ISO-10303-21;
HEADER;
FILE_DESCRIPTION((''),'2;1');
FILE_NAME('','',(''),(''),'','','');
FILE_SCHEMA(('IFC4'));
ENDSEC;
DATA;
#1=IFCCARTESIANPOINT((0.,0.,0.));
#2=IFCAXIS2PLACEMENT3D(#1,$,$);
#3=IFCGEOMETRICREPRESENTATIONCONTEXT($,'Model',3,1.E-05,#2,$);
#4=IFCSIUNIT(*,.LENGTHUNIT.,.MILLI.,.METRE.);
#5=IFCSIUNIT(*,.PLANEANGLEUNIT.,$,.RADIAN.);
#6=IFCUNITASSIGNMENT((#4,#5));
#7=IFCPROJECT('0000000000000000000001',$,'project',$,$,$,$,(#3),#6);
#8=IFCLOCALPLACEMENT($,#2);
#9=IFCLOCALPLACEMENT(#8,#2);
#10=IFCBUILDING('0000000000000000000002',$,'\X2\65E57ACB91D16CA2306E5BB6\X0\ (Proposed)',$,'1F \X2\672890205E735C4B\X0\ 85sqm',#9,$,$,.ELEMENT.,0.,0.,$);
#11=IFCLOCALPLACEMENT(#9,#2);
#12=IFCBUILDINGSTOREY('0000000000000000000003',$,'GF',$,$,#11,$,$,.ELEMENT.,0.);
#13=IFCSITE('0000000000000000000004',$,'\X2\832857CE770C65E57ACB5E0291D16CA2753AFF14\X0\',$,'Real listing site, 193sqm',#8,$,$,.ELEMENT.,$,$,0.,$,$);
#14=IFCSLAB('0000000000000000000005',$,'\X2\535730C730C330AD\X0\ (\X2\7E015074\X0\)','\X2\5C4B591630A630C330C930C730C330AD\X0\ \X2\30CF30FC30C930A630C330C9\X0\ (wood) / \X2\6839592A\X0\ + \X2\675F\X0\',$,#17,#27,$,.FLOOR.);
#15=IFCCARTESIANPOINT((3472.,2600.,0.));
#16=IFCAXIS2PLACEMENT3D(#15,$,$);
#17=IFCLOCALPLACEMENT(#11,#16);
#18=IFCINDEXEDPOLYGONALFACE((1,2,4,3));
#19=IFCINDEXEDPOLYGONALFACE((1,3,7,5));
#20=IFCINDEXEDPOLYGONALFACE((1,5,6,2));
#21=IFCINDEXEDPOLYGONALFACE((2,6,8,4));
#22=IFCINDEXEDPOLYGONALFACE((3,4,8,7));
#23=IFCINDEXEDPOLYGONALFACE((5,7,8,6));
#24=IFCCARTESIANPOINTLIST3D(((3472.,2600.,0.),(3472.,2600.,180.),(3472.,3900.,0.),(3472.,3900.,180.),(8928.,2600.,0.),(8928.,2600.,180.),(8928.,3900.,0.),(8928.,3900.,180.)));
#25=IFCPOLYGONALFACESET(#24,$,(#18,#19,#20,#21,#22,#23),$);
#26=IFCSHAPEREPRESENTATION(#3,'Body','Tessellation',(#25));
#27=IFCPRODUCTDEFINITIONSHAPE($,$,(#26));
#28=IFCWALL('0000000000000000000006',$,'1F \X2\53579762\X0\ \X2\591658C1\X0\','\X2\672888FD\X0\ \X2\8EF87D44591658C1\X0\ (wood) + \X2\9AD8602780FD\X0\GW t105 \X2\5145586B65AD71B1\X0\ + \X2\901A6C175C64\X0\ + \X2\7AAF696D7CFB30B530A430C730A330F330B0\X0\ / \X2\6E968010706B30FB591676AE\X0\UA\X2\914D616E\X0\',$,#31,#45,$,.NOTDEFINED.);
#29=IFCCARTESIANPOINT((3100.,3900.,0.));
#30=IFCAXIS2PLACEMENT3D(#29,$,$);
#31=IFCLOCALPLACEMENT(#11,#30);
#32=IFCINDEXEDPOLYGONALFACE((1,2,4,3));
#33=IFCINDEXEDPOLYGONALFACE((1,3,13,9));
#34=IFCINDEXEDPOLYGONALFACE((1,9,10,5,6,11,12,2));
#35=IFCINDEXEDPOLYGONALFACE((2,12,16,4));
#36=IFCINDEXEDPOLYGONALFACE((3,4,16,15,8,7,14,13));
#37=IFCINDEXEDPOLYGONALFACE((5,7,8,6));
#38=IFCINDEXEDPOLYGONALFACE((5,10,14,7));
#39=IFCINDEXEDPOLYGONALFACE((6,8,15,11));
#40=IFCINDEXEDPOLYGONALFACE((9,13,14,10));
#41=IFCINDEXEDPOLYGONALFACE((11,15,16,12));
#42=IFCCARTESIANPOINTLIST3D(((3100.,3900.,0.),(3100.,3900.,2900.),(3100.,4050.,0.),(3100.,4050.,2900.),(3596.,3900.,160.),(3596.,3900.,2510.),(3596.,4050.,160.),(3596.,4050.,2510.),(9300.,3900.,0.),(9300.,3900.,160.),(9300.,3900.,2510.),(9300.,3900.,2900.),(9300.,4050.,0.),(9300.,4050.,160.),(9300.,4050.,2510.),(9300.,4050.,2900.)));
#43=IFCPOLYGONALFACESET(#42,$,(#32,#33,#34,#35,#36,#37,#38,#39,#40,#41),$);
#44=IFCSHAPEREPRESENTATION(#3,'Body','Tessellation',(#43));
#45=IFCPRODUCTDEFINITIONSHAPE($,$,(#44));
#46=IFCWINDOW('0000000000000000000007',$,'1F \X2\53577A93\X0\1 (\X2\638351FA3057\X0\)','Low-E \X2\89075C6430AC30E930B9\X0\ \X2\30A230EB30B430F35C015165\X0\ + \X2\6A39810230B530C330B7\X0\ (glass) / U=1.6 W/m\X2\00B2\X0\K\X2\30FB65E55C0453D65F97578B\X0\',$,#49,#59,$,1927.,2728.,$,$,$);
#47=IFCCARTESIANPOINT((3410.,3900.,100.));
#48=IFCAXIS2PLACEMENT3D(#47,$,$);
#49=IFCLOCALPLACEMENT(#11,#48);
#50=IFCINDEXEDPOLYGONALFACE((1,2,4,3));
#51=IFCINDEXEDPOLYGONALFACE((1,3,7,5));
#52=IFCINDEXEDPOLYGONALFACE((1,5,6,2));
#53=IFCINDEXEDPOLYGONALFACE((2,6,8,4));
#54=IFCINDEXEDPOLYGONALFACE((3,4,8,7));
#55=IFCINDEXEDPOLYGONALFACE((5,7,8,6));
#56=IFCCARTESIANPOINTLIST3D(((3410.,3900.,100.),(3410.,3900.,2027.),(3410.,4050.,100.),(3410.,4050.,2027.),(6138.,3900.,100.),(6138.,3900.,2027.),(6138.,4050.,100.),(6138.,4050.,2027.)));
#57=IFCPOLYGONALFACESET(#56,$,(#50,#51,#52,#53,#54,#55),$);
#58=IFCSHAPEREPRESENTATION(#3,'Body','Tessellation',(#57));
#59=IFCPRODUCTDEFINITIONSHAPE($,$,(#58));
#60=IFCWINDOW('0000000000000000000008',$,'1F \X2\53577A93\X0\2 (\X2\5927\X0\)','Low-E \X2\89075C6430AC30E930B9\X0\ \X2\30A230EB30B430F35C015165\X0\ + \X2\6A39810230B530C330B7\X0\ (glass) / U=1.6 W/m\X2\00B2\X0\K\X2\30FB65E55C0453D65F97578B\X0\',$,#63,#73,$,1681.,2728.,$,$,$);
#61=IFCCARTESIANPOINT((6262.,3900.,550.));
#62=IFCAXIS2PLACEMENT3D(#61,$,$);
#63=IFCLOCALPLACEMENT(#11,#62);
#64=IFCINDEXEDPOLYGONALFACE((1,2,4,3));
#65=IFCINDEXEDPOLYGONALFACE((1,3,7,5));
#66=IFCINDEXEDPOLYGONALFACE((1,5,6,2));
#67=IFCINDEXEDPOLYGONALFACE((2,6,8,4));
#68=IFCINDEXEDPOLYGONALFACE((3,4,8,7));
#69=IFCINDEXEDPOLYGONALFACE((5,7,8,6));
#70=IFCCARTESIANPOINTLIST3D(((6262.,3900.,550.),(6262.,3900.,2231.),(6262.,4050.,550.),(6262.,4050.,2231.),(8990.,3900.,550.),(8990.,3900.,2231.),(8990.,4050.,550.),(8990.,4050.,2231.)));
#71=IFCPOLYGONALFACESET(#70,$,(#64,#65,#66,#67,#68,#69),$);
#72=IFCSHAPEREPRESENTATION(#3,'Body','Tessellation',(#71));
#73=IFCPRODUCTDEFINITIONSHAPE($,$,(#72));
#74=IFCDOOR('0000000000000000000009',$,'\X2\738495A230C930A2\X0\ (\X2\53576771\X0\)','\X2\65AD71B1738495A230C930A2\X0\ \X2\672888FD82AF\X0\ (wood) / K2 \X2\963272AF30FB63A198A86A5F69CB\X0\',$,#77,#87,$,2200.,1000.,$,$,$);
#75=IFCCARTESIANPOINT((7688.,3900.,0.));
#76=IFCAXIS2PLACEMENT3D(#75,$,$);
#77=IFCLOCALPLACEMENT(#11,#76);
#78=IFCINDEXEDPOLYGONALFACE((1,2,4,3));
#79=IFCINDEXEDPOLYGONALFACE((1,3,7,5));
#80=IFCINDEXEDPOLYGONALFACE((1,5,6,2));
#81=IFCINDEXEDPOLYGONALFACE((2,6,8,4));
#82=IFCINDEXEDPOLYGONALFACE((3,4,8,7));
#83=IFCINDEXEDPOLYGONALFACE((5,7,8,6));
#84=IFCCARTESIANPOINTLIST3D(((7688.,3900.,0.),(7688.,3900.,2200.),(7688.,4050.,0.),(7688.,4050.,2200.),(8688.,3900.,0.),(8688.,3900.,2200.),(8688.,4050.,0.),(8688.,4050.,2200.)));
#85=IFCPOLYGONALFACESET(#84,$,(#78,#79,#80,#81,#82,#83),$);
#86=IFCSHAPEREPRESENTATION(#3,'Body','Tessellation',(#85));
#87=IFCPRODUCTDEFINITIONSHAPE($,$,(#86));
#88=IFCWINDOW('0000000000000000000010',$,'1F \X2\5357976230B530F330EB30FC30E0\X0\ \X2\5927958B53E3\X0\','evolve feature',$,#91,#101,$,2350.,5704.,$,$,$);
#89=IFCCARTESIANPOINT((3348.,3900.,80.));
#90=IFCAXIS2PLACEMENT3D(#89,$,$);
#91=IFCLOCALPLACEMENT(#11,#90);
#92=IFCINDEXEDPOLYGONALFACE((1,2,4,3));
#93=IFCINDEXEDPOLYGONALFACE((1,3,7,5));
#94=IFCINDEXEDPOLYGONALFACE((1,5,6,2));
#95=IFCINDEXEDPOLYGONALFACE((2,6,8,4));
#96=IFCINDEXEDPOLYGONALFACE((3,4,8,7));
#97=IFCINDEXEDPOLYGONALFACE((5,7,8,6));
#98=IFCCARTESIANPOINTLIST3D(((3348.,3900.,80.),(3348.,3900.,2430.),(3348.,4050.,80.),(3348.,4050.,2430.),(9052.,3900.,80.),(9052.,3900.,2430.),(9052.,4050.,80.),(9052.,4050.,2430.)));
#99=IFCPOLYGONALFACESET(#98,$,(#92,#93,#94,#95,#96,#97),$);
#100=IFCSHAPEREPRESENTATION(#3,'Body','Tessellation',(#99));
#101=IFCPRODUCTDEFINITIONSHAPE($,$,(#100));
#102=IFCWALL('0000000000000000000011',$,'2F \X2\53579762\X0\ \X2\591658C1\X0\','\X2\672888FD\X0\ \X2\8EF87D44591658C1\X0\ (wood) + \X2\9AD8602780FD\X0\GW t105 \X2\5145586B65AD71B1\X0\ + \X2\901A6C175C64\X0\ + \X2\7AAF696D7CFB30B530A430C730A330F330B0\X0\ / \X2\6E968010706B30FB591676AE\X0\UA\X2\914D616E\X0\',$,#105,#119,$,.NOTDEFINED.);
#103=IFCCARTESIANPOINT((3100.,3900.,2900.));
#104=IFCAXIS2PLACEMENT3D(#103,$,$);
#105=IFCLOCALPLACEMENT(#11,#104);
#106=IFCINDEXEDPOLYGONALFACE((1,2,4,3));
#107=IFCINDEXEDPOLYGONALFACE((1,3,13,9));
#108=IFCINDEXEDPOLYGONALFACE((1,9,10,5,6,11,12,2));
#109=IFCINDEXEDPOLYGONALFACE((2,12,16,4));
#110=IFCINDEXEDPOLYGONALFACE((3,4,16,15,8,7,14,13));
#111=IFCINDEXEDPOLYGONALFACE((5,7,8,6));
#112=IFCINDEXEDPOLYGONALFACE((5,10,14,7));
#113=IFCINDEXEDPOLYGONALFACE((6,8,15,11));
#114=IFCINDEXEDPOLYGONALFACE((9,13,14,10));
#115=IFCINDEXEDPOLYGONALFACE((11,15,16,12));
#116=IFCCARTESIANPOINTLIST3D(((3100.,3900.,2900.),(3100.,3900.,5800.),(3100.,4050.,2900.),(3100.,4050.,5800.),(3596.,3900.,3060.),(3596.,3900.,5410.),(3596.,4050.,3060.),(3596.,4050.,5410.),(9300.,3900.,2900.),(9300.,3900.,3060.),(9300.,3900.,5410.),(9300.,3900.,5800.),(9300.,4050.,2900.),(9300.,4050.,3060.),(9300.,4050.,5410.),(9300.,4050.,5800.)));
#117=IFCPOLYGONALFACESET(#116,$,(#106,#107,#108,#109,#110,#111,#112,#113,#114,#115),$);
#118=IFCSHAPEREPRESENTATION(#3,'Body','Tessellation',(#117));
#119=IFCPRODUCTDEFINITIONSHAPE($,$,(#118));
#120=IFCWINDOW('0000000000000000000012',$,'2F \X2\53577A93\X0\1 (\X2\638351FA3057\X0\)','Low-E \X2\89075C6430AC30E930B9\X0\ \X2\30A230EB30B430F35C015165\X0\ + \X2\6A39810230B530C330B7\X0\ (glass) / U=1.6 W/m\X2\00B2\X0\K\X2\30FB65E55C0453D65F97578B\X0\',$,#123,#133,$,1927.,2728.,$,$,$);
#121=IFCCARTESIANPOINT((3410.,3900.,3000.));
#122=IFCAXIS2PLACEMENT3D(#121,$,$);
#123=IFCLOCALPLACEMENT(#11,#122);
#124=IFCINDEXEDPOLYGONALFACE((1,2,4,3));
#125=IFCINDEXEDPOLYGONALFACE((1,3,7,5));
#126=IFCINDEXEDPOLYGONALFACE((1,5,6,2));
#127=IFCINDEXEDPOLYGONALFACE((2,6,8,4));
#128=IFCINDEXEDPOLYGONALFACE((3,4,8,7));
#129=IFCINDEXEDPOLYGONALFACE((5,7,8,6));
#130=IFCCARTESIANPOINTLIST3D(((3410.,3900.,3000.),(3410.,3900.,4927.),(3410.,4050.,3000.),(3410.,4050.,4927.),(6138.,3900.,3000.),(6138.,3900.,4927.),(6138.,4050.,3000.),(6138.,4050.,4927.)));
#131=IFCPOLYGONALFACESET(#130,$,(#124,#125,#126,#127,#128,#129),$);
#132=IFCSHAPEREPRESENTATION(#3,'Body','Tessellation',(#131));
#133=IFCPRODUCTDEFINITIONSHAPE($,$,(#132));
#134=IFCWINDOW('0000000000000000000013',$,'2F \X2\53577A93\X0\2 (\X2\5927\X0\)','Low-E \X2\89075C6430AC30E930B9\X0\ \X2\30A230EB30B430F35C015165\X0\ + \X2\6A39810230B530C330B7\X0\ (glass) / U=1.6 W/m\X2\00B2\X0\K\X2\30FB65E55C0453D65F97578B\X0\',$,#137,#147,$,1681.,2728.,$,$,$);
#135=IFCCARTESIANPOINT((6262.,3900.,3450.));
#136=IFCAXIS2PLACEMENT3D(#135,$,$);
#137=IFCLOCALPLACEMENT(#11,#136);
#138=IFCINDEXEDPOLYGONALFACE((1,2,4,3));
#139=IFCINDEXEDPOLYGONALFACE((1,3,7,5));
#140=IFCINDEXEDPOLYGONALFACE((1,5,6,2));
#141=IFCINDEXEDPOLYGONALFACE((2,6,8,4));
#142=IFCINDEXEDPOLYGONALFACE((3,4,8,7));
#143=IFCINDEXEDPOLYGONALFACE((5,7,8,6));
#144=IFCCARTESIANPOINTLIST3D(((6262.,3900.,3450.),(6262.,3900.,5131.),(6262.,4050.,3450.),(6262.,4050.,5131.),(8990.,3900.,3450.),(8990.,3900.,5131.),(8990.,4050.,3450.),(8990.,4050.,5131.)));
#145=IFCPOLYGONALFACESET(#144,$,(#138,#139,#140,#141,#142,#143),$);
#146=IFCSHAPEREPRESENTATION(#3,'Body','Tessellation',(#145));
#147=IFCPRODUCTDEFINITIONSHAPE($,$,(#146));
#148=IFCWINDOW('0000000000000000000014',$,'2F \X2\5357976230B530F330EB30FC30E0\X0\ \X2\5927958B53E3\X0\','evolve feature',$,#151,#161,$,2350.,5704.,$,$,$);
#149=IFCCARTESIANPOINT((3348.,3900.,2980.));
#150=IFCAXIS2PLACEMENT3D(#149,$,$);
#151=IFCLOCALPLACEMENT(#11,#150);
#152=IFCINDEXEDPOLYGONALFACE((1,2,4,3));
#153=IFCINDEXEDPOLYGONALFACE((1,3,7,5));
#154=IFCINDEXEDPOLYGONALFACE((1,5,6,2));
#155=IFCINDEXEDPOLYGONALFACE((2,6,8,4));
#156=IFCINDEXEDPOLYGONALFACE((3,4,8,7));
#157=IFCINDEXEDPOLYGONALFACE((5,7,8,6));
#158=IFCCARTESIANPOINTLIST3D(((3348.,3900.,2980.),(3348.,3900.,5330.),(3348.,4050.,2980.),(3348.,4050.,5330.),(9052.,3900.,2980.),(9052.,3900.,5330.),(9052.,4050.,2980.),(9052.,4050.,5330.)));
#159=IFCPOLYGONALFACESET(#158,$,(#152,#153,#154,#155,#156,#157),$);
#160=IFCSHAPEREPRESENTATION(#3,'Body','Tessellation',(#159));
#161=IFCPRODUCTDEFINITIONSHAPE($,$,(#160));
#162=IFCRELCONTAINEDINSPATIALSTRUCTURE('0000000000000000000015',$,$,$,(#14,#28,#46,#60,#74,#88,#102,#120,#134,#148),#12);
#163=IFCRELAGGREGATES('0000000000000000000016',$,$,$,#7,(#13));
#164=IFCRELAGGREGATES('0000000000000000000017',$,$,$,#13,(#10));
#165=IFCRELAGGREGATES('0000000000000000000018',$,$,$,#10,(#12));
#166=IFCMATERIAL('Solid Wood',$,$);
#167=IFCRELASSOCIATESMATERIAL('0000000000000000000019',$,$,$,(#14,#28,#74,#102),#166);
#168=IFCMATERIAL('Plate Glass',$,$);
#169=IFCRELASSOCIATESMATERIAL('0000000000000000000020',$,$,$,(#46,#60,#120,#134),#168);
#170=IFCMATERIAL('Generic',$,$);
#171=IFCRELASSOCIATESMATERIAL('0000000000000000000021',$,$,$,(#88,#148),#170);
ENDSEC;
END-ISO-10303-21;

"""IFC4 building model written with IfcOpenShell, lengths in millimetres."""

from ifc_helpers import new_model, si_unit, frame, frame_2d, origin, place, context, project, spatial, rectangle, extrude, material, element, fill, save


model = new_model("IFC4")

# Units and contexts
model_context = context("Model", 3, precision=1e-05, world=origin())
ifc_project = project(units=[si_unit("LENGTHUNIT", "METRE", prefix="MILLI"), si_unit("PLANEANGLEUNIT", "RADIAN")], contexts=[model_context])

# Site, building, storey
site_placement = place(None, origin())
site = spatial("IfcSite", under=ifc_project, at=site_placement, Name="茨城県日立市金沢町４", ObjectType="Real listing site, 193sqm", CompositionType="ELEMENT", RefElevation=0.0)
building_placement = place(site_placement, origin())
building = spatial("IfcBuilding", under=site, at=building_placement, Name="日立金沢の家 (Proposed)", ObjectType="1F 木造平屋 85sqm", CompositionType="ELEMENT", ElevationOfRefHeight=0.0, ElevationOfTerrain=0.0)
storey_placement = place(building_placement, origin())
storey = spatial("IfcBuildingStorey", under=building, at=storey_placement, Name="GF", CompositionType="ELEMENT", Elevation=0.0)

# Slab
ifc_material_1 = material(Name="Solid Wood")
slab_1_placement = place(storey_placement, frame((3472.0, 2600.0, 0.0)))
element("IfcSlab", 1, at=slab_1_placement, inside=storey, material=ifc_material_1, Name="南デッキ (縁側)", Description="屋外ウッドデッキ ハードウッド (wood) / 根太 + 束", PredefinedType="FLOOR", context=model_context, shape_type="SweptSolid", body=[
    extrude(rectangle(XDim=5456.0, YDim=1300.0, at=frame_2d((2728.0, 650.0))), frame((3472.0, 2600.0, 0.0)), (0.0, 0.0, 1.0), 180.0),
])
ifc_material_2 = material(Name="Generic")

# Wall, openings, windows, door
wall_1_placement = place(storey_placement, frame((3100.0, 3900.0, 0.0)))
wall_1 = element("IfcWall", 2, at=wall_1_placement, inside=storey, material=ifc_material_1, Name="1F 南面 外壁", Description="木製 軸組外壁 (wood) + 高性能GW t105 充填断熱 + 通気層 + 窯業系サイディング / 準耐火・外皮UA配慮", PredefinedType="NOTDEFINED", context=model_context, shape_type="SweptSolid", body=[
    extrude(rectangle(XDim=6200.0, YDim=150.0, at=frame_2d((3100.0, 75.0))), frame((3100.0, 3900.0, 0.0)), (0.0, 0.0, 1.0), 2900.0),
])
opening_1_placement = place(storey_placement, frame((3410.0, 3900.0, 100.0)))
opening_1 = element("IfcOpeningElement", 3, at=opening_1_placement, cuts=wall_1, PredefinedType="NOTDEFINED", context=model_context, shape_type="SweptSolid", body=[
    extrude(rectangle(XDim=2728.0, YDim=150.0, at=frame_2d((1364.0, 75.0))), frame((3410.0, 3900.0, 100.0)), (0.0, 0.0, 1.0), 1927.0),
])
opening_2_placement = place(storey_placement, frame((6262.0, 3900.0, 550.0)))
opening_2 = element("IfcOpeningElement", 4, at=opening_2_placement, cuts=wall_1, PredefinedType="NOTDEFINED", context=model_context, shape_type="SweptSolid", body=[
    extrude(rectangle(XDim=2728.0, YDim=150.0, at=frame_2d((1364.0, 75.0))), frame((6262.0, 3900.0, 550.0)), (0.0, 0.0, 1.0), 1681.0),
])
opening_3_placement = place(storey_placement, frame((7688.0, 3900.0, 0.0)))
opening_3 = element("IfcOpeningElement", 5, at=opening_3_placement, cuts=wall_1, PredefinedType="NOTDEFINED", context=model_context, shape_type="SweptSolid", body=[
    extrude(rectangle(XDim=1000.0, YDim=150.0, at=frame_2d((500.0, 75.0))), frame((7688.0, 3900.0, 0.0)), (0.0, 0.0, 1.0), 2200.0),
])
opening_4_placement = place(storey_placement, frame((3348.0, 3900.0, 80.0)))
opening_4 = element("IfcOpeningElement", 6, at=opening_4_placement, cuts=wall_1, PredefinedType="NOTDEFINED", context=model_context, shape_type="SweptSolid", body=[
    extrude(rectangle(XDim=5704.0, YDim=150.0, at=frame_2d((2852.0, 75.0))), frame((3348.0, 3900.0, 80.0)), (0.0, 0.0, 1.0), 2350.0),
])
ifc_material_3 = material(Name="Plate Glass")
window_1_placement = place(storey_placement, frame((3410.0, 3900.0, 100.0)))
window_1 = element("IfcWindow", 7, at=window_1_placement, inside=storey, material=ifc_material_3, Name="1F 南窓1 (掃出し)", Description="Low-E 複層ガラス アルゴン封入 + 樹脂サッシ (glass) / U=1.6 W/m²K・日射取得型", OverallHeight=1927.0, OverallWidth=2728.0, context=model_context, shape_type="SweptSolid", body=[
    extrude(rectangle(XDim=2728.0, YDim=150.0, at=frame_2d((1364.0, 75.0))), frame((3410.0, 3900.0, 100.0)), (0.0, 0.0, 1.0), 1927.0),
])
fill(opening_1, window_1)
window_2_placement = place(storey_placement, frame((6262.0, 3900.0, 550.0)))
window_2 = element("IfcWindow", 8, at=window_2_placement, inside=storey, material=ifc_material_3, Name="1F 南窓2 (大)", Description="Low-E 複層ガラス アルゴン封入 + 樹脂サッシ (glass) / U=1.6 W/m²K・日射取得型", OverallHeight=1681.0, OverallWidth=2728.0, context=model_context, shape_type="SweptSolid", body=[
    extrude(rectangle(XDim=2728.0, YDim=150.0, at=frame_2d((1364.0, 75.0))), frame((6262.0, 3900.0, 550.0)), (0.0, 0.0, 1.0), 1681.0),
])
fill(opening_2, window_2)
door_placement = place(storey_placement, frame((7688.0, 3900.0, 0.0)))
door = element("IfcDoor", 9, at=door_placement, inside=storey, material=ifc_material_1, Name="玄関ドア (南東)", Description="断熱玄関ドア 木製芯 (wood) / K2 防犯・採風機構", OverallHeight=2200.0, OverallWidth=1000.0, context=model_context, shape_type="SweptSolid", body=[
    extrude(rectangle(XDim=1000.0, YDim=150.0, at=frame_2d((500.0, 75.0))), frame((7688.0, 3900.0, 0.0)), (0.0, 0.0, 1.0), 2200.0),
])
fill(opening_3, door)
window_3_placement = place(storey_placement, frame((3348.0, 3900.0, 80.0)))
window_3 = element("IfcWindow", 10, at=window_3_placement, inside=storey, material=ifc_material_2, Name="1F 南面サンルーム 大開口", Description="evolve feature", OverallHeight=2350.0, OverallWidth=5704.0, context=model_context, shape_type="SweptSolid", body=[
    extrude(rectangle(XDim=5704.0, YDim=150.0, at=frame_2d((2852.0, 75.0))), frame((3348.0, 3900.0, 80.0)), (0.0, 0.0, 1.0), 2350.0),
])
fill(opening_4, window_3)

# Wall, openings, windows
wall_2_placement = place(storey_placement, frame((3100.0, 3900.0, 2900.0)))
wall_2 = element("IfcWall", 11, at=wall_2_placement, inside=storey, material=ifc_material_1, Name="2F 南面 外壁", Description="木製 軸組外壁 (wood) + 高性能GW t105 充填断熱 + 通気層 + 窯業系サイディング / 準耐火・外皮UA配慮", PredefinedType="NOTDEFINED", context=model_context, shape_type="SweptSolid", body=[
    extrude(rectangle(XDim=6200.0, YDim=150.0, at=frame_2d((3100.0, 75.0))), frame((3100.0, 3900.0, 2900.0)), (0.0, 0.0, 1.0), 2900.0),
])
opening_5_placement = place(storey_placement, frame((3410.0, 3900.0, 3000.0)))
opening_5 = element("IfcOpeningElement", 12, at=opening_5_placement, cuts=wall_2, PredefinedType="NOTDEFINED", context=model_context, shape_type="SweptSolid", body=[
    extrude(rectangle(XDim=2728.0, YDim=150.0, at=frame_2d((1364.0, 75.0))), frame((3410.0, 3900.0, 3000.0)), (0.0, 0.0, 1.0), 1927.0),
])
opening_6_placement = place(storey_placement, frame((6262.0, 3900.0, 3450.0)))
opening_6 = element("IfcOpeningElement", 13, at=opening_6_placement, cuts=wall_2, PredefinedType="NOTDEFINED", context=model_context, shape_type="SweptSolid", body=[
    extrude(rectangle(XDim=2728.0, YDim=150.0, at=frame_2d((1364.0, 75.0))), frame((6262.0, 3900.0, 3450.0)), (0.0, 0.0, 1.0), 1681.0),
])
opening_7_placement = place(storey_placement, frame((3348.0, 3900.0, 2980.0)))
opening_7 = element("IfcOpeningElement", 14, at=opening_7_placement, cuts=wall_2, PredefinedType="NOTDEFINED", context=model_context, shape_type="SweptSolid", body=[
    extrude(rectangle(XDim=5704.0, YDim=150.0, at=frame_2d((2852.0, 75.0))), frame((3348.0, 3900.0, 2980.0)), (0.0, 0.0, 1.0), 2350.0),
])
window_4_placement = place(storey_placement, frame((3410.0, 3900.0, 3000.0)))
window_4 = element("IfcWindow", 15, at=window_4_placement, inside=storey, material=ifc_material_3, Name="2F 南窓1 (掃出し)", Description="Low-E 複層ガラス アルゴン封入 + 樹脂サッシ (glass) / U=1.6 W/m²K・日射取得型", OverallHeight=1927.0, OverallWidth=2728.0, context=model_context, shape_type="SweptSolid", body=[
    extrude(rectangle(XDim=2728.0, YDim=150.0, at=frame_2d((1364.0, 75.0))), frame((3410.0, 3900.0, 3000.0)), (0.0, 0.0, 1.0), 1927.0),
])
fill(opening_5, window_4)
window_5_placement = place(storey_placement, frame((6262.0, 3900.0, 3450.0)))
window_5 = element("IfcWindow", 16, at=window_5_placement, inside=storey, material=ifc_material_3, Name="2F 南窓2 (大)", Description="Low-E 複層ガラス アルゴン封入 + 樹脂サッシ (glass) / U=1.6 W/m²K・日射取得型", OverallHeight=1681.0, OverallWidth=2728.0, context=model_context, shape_type="SweptSolid", body=[
    extrude(rectangle(XDim=2728.0, YDim=150.0, at=frame_2d((1364.0, 75.0))), frame((6262.0, 3900.0, 3450.0)), (0.0, 0.0, 1.0), 1681.0),
])
fill(opening_6, window_5)
window_6_placement = place(storey_placement, frame((3348.0, 3900.0, 2980.0)))
window_6 = element("IfcWindow", 17, at=window_6_placement, inside=storey, material=ifc_material_2, Name="2F 南面サンルーム 大開口", Description="evolve feature", OverallHeight=2350.0, OverallWidth=5704.0, context=model_context, shape_type="SweptSolid", body=[
    extrude(rectangle(XDim=5704.0, YDim=150.0, at=frame_2d((2852.0, 75.0))), frame((3348.0, 3900.0, 2980.0)), (0.0, 0.0, 1.0), 2350.0),
])
fill(opening_7, window_6)

save(model, "model.ifc")
